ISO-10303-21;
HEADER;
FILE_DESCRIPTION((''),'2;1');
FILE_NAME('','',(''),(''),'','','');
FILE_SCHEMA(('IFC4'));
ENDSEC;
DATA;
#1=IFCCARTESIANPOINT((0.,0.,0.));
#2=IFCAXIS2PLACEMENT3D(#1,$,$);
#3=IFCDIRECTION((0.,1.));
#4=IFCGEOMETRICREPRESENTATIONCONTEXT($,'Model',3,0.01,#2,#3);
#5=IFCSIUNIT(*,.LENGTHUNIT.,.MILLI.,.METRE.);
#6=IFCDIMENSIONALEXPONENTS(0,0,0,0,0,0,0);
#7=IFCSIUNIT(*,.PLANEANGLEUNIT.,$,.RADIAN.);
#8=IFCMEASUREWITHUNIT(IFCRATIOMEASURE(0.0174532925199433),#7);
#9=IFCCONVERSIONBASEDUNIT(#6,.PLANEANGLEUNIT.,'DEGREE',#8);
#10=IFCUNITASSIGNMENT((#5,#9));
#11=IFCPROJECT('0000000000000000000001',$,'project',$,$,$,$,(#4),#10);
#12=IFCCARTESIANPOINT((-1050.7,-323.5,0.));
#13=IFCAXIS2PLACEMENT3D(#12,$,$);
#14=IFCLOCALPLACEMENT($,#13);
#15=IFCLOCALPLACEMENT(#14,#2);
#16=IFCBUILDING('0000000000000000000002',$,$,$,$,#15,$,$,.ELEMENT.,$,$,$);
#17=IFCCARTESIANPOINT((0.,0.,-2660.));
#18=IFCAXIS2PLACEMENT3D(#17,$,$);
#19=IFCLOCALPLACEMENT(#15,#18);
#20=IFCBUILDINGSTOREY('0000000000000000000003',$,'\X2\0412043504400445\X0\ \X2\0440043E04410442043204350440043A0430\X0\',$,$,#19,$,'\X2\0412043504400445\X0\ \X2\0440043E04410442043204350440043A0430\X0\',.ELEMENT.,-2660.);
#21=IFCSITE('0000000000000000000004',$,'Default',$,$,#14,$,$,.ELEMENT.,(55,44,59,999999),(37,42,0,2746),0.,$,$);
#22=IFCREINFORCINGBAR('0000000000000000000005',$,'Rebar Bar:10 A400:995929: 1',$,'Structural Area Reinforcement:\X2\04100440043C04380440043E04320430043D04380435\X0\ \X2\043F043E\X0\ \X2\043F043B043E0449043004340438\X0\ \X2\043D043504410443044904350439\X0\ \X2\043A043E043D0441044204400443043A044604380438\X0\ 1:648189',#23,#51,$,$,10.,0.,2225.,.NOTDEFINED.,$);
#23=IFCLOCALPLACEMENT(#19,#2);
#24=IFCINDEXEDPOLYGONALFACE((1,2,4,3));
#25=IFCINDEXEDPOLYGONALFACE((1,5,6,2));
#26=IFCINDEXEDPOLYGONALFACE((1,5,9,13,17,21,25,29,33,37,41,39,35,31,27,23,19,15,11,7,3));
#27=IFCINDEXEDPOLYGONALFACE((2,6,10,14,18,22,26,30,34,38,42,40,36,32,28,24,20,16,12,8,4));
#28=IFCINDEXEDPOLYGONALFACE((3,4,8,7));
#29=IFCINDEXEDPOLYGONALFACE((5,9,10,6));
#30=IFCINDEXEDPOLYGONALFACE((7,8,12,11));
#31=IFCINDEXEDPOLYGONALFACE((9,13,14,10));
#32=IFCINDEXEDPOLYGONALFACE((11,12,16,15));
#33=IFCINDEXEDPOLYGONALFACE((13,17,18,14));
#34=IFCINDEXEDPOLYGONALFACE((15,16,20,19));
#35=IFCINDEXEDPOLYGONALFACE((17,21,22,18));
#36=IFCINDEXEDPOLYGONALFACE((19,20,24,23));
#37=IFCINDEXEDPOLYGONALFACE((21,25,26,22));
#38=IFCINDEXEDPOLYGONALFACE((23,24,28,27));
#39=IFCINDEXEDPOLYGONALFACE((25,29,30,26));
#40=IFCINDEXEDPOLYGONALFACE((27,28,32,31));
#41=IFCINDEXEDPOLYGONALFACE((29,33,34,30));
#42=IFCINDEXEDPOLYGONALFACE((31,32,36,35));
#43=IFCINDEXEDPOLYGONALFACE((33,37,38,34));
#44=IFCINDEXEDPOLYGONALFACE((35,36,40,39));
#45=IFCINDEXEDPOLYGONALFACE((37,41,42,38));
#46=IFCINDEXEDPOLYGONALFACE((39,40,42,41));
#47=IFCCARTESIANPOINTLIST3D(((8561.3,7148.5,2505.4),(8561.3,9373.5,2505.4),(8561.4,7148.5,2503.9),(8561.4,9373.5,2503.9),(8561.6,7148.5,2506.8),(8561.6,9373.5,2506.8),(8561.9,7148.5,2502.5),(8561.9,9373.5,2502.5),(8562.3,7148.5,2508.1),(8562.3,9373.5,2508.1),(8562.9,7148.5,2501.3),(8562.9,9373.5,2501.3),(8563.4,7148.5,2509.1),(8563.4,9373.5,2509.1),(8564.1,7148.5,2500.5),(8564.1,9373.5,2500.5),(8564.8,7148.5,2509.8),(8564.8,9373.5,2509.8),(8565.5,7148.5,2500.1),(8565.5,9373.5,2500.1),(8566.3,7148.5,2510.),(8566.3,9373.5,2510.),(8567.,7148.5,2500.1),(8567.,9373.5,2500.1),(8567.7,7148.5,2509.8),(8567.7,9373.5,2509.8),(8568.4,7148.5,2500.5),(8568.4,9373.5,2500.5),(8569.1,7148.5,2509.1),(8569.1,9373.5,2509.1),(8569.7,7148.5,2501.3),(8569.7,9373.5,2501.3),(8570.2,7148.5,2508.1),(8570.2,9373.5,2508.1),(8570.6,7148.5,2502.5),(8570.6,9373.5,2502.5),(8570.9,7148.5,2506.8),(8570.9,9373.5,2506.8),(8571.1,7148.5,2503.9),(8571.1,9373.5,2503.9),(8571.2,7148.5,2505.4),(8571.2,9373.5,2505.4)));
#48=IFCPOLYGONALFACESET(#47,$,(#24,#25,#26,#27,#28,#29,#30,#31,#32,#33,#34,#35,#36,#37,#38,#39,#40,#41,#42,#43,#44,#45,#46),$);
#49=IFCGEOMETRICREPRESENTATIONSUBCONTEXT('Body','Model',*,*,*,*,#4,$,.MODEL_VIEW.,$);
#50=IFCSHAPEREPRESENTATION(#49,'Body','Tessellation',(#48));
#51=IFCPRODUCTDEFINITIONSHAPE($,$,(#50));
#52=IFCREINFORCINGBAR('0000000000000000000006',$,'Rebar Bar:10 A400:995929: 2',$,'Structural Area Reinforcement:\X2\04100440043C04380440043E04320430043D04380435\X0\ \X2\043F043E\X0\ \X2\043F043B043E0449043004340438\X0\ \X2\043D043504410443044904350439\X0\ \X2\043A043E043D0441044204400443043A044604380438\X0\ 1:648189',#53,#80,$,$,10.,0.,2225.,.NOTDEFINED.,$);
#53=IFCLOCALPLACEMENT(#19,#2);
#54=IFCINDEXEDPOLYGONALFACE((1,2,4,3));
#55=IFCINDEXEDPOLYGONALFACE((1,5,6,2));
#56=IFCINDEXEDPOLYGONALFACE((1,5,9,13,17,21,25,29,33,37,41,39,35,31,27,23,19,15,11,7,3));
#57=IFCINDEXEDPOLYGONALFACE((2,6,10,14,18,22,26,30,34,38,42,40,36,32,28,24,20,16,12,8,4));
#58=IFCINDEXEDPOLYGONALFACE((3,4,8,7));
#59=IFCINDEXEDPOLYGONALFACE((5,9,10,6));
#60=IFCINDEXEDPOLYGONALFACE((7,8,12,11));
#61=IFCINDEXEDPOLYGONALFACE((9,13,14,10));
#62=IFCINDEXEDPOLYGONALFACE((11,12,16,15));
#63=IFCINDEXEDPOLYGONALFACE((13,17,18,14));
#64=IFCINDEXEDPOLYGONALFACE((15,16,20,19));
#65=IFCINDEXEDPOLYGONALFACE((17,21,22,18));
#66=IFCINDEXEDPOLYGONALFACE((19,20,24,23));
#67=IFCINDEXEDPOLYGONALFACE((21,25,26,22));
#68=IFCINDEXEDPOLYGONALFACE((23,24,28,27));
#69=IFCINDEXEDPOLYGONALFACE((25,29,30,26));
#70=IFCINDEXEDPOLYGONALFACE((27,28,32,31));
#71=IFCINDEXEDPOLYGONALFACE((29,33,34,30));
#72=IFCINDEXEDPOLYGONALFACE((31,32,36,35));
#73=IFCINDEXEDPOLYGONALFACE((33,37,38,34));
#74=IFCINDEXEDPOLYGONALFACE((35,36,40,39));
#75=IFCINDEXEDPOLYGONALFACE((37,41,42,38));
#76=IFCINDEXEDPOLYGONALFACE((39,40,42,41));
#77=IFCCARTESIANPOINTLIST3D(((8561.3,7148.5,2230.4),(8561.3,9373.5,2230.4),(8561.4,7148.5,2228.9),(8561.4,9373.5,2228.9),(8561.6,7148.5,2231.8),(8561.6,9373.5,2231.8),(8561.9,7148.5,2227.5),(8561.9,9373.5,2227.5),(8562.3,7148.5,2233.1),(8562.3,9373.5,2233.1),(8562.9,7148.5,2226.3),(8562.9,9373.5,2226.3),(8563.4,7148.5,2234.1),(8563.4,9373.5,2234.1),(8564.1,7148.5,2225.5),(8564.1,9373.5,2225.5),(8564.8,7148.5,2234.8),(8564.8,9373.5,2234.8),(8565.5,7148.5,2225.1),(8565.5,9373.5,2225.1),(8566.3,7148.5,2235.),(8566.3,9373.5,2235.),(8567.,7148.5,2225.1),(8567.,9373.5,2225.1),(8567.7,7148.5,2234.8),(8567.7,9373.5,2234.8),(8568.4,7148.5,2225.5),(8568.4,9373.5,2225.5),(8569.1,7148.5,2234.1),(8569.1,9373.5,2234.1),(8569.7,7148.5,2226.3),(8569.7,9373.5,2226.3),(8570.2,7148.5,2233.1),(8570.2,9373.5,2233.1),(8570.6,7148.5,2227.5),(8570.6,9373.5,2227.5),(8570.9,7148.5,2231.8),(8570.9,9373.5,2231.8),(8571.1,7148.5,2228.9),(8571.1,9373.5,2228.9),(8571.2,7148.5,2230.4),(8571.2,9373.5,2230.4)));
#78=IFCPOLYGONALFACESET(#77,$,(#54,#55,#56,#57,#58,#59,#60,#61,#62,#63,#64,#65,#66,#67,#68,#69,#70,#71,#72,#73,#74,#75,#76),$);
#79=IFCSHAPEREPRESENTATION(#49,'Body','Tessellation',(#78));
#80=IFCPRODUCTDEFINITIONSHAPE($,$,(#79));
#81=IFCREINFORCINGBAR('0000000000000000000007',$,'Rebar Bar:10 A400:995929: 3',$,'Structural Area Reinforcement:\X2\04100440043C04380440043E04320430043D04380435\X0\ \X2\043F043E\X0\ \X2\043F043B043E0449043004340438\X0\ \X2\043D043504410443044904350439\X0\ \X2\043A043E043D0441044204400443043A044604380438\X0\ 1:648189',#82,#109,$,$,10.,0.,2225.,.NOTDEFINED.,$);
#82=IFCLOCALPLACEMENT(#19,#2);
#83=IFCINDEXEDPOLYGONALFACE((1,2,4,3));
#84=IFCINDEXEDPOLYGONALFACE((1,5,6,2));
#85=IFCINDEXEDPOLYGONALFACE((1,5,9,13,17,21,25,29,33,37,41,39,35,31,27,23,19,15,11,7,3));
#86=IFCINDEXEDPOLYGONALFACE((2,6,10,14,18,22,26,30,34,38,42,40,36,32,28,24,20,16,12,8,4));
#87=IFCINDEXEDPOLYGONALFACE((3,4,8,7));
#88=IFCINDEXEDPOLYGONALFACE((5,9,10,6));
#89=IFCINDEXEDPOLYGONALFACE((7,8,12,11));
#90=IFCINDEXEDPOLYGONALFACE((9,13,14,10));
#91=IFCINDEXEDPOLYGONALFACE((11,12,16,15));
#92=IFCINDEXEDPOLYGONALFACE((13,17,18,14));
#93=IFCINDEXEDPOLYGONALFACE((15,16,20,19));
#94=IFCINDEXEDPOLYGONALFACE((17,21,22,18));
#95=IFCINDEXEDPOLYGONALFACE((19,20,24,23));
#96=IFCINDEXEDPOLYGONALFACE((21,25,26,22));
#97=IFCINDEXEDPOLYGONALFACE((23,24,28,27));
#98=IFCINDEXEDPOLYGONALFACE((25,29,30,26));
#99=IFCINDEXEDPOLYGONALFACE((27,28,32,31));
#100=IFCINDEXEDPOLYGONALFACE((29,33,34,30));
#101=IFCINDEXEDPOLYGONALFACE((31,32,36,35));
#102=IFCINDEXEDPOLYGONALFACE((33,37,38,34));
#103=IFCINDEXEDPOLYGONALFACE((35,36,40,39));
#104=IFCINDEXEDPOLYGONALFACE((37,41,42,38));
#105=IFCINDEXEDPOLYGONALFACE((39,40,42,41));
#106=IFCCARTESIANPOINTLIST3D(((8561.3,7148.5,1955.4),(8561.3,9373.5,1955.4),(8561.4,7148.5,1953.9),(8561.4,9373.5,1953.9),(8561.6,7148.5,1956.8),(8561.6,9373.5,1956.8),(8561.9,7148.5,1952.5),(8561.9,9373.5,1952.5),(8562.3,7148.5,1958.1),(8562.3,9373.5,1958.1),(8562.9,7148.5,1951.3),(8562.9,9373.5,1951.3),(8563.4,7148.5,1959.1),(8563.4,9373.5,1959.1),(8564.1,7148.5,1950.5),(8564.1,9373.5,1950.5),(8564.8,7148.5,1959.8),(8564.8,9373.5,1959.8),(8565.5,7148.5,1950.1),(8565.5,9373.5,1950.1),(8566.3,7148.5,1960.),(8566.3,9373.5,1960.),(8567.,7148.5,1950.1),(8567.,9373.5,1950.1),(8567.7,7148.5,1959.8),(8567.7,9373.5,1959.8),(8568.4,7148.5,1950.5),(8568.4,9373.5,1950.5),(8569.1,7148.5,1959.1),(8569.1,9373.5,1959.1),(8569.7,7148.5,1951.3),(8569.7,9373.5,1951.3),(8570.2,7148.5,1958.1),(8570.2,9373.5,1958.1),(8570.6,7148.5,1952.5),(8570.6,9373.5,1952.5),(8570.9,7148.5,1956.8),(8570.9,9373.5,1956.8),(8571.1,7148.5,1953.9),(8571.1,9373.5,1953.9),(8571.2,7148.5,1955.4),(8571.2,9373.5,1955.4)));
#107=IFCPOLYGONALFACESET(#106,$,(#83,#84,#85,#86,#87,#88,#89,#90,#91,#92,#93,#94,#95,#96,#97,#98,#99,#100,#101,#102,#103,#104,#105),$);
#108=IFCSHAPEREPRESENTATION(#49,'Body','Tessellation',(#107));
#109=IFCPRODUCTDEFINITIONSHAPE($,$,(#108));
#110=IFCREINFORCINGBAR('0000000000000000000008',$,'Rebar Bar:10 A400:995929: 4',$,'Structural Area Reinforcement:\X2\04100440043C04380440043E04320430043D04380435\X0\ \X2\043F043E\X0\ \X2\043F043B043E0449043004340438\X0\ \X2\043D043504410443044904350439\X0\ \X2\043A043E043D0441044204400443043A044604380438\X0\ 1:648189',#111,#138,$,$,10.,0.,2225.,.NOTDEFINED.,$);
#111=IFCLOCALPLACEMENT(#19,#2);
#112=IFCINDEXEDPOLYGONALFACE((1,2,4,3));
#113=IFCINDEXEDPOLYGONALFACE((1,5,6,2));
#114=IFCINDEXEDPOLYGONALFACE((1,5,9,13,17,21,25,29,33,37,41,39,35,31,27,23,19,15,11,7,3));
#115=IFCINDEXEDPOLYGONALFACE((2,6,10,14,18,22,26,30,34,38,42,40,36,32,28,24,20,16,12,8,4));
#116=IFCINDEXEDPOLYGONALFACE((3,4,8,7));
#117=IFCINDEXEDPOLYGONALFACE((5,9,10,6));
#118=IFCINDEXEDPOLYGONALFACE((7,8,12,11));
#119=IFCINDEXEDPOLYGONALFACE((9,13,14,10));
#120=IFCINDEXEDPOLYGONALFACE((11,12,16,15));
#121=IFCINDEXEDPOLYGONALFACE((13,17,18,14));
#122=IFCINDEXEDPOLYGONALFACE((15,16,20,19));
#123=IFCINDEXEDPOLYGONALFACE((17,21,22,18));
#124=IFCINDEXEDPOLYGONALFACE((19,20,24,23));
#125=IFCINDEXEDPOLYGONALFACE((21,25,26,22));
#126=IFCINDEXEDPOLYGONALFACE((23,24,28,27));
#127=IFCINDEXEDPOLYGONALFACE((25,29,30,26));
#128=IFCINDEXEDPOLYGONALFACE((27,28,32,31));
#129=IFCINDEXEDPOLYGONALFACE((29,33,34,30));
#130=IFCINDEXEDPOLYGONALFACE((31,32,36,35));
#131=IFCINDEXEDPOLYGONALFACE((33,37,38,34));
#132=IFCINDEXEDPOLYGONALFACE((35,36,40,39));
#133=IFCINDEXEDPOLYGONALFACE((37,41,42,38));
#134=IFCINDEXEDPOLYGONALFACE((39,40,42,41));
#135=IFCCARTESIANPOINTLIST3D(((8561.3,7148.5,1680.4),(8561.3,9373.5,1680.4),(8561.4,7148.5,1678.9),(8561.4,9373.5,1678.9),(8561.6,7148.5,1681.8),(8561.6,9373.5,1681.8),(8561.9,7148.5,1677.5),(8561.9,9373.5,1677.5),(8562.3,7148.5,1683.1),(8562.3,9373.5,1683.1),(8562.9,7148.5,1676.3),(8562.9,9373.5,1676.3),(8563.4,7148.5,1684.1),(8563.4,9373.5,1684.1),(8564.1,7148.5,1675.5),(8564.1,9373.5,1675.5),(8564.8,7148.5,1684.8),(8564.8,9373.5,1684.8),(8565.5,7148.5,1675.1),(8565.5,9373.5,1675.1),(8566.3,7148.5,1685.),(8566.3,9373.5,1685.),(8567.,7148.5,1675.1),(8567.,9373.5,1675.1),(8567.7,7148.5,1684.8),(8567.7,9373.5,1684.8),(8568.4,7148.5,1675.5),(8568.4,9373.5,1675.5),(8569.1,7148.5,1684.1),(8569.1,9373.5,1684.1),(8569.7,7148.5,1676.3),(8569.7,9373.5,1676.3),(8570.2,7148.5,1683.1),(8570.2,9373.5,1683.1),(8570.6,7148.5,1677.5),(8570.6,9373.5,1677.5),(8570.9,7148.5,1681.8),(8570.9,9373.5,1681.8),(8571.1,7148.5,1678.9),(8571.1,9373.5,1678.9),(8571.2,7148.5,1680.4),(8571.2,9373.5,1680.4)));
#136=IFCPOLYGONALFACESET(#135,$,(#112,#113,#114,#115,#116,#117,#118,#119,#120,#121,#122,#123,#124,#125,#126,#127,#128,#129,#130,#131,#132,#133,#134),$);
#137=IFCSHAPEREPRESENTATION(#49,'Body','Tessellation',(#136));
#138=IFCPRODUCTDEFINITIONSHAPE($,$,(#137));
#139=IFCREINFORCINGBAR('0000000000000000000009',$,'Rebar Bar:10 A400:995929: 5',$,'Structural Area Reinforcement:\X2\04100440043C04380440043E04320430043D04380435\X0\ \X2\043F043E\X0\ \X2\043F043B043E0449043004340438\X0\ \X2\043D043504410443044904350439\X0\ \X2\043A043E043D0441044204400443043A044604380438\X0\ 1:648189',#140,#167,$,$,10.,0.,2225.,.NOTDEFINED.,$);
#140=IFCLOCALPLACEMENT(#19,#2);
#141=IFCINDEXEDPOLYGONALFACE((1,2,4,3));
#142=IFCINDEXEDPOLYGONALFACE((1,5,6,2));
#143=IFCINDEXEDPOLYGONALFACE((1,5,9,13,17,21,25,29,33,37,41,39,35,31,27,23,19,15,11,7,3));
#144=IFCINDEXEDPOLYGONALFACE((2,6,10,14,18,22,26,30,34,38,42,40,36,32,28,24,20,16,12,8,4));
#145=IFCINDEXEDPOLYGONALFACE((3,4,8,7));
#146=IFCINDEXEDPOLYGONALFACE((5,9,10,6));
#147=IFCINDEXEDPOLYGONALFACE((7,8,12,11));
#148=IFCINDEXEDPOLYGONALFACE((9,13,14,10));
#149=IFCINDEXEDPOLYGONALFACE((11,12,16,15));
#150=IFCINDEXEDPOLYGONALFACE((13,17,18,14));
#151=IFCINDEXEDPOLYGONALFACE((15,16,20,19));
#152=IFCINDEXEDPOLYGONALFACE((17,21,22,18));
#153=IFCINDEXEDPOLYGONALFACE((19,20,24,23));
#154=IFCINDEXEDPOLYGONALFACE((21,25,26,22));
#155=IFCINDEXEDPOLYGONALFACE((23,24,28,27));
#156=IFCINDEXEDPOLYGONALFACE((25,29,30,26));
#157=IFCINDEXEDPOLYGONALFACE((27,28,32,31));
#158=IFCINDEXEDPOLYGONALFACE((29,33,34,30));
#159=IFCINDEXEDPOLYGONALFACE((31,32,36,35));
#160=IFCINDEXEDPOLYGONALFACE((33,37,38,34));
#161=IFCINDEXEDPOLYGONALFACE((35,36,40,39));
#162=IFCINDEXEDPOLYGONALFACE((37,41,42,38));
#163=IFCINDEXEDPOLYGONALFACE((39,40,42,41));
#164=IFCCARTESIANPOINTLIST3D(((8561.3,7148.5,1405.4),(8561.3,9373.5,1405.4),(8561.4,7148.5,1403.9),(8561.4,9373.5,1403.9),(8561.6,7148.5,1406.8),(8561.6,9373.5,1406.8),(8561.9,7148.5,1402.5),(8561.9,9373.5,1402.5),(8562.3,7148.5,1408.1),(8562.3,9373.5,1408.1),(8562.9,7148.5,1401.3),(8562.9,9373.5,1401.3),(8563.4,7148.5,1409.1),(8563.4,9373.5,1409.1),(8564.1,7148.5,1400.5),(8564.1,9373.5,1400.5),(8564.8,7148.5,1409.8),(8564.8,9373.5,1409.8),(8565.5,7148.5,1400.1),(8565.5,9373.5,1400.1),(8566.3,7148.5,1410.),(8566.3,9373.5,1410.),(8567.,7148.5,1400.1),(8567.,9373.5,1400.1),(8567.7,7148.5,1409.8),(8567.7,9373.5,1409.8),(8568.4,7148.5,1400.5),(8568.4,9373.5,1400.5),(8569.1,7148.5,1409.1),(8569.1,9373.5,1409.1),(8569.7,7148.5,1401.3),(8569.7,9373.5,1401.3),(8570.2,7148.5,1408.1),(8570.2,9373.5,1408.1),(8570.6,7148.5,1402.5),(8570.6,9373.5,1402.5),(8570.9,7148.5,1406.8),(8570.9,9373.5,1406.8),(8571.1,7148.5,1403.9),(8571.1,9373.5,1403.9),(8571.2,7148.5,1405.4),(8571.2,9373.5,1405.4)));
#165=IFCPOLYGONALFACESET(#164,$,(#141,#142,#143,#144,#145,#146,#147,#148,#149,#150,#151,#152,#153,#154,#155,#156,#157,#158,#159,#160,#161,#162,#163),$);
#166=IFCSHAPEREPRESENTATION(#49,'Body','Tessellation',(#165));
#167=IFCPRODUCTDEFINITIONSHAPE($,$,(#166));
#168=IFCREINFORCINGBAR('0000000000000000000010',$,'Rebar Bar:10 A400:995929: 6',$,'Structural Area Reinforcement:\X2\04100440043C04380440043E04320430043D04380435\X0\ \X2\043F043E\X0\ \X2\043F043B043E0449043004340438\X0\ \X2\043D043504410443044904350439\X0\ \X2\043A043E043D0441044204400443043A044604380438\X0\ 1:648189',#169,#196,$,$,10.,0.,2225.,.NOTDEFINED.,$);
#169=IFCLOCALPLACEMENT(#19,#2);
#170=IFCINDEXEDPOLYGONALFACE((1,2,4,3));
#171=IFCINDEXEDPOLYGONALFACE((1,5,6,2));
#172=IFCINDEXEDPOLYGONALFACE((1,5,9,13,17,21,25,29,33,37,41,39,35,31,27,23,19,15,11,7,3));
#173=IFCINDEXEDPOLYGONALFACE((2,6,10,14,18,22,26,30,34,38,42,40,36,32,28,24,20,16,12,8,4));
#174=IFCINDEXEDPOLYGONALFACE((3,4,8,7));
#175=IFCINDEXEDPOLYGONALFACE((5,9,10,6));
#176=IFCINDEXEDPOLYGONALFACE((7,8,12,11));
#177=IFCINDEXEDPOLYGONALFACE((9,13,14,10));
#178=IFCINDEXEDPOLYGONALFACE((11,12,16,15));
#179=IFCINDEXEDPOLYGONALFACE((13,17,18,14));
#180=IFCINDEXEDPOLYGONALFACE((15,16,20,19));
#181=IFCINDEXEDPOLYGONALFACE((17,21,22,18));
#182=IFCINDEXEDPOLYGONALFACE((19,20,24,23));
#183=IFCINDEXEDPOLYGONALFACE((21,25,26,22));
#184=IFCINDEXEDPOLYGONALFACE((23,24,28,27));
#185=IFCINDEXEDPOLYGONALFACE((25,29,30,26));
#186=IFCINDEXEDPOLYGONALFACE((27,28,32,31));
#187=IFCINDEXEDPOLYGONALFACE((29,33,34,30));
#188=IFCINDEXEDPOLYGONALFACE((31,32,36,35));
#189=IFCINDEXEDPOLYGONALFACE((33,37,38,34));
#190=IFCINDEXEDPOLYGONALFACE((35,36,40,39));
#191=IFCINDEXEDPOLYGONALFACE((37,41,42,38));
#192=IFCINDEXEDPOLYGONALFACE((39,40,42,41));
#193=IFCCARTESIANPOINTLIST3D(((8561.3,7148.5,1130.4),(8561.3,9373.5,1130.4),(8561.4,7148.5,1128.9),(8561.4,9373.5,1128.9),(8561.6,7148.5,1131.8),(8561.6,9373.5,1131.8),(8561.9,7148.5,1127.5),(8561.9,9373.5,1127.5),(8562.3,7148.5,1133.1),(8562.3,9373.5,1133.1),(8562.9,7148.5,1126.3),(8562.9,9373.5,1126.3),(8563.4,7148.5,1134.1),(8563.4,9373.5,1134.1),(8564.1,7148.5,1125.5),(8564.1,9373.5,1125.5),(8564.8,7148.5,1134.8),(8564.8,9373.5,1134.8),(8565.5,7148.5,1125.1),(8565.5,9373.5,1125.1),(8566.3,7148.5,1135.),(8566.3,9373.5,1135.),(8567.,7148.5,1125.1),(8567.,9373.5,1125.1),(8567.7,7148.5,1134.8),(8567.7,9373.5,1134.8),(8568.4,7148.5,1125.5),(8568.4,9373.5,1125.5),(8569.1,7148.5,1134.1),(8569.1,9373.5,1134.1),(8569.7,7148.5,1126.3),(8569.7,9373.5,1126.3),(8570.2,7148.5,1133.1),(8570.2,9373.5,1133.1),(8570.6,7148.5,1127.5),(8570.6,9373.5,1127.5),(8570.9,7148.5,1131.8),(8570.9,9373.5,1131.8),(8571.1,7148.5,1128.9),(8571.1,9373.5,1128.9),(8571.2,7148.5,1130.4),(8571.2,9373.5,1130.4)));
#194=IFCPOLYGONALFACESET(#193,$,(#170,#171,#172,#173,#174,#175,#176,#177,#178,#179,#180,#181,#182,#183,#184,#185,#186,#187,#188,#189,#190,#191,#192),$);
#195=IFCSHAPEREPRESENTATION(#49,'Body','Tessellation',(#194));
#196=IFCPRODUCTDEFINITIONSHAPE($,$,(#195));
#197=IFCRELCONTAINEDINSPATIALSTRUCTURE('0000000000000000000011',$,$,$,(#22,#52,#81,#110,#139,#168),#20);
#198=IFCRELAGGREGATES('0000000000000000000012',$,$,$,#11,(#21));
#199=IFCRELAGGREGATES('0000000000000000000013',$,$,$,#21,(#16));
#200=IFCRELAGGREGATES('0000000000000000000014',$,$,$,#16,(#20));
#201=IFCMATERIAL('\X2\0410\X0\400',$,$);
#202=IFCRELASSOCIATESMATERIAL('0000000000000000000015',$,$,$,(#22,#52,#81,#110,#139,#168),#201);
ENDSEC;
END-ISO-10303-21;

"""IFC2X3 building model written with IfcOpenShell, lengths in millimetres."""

from ifc_helpers import new_model, entity, si_unit, converted_unit, direction, frame, origin, place, context, subcontext, project, spatial, material, element, save


model = new_model("IFC2X3")

# Units and contexts
model_context = context("Model", 3, precision=0.01, world=origin(), true_north=direction((0.0, 1.0)))
body_context = subcontext(model_context, "Body", "Model", "MODEL_VIEW")
ifc_project = project(units=[si_unit("LENGTHUNIT", "METRE", prefix="MILLI"), converted_unit("PLANEANGLEUNIT", "DEGREE", entity("IfcRatioMeasure", 0.0174532925199433), si_unit("PLANEANGLEUNIT", "RADIAN"), dimensions=[0, 0, 0, 0, 0, 0, 0])], contexts=[model_context])

# Site, building, storey
site_placement = place(None, frame((-1050.7, -323.5, 0.0)))
site = spatial("IfcSite", under=ifc_project, at=site_placement, Name="Default", CompositionType="ELEMENT", RefLatitude=(55, 44, 59, 999999), RefLongitude=(37, 42, 0, 2746), RefElevation=0.0)
building_placement = place(site_placement, origin())
building = spatial("IfcBuilding", under=site, at=building_placement, CompositionType="ELEMENT")
storey_placement = place(building_placement, frame((0.0, 0.0, -2660.0)))
storey = spatial("IfcBuildingStorey", under=building, at=storey_placement, Name="Верх ростверка", LongName="Верх ростверка", CompositionType="ELEMENT", Elevation=-2660.0)

# Reinforcing bars
ifc_material = material(Name="А400")
reinforcing_bar_1_placement = place(storey_placement, origin())
element("IfcReinforcingBar", 1, at=reinforcing_bar_1_placement, inside=storey, material=ifc_material, Name="Rebar Bar:10 A400:995929: 1", ObjectType="Structural Area Reinforcement:Армирование по площади несущей конструкции 1:648189", BarLength=2225.0, BarRole="NOTDEFINED", CrossSectionArea=0.0, NominalDiameter=10.0, context=body_context, shape_type="AdvancedSweptSolid", body=[
    entity("IfcSweptDiskSolid", entity("IfcCompositeCurve", [entity("IfcCompositeCurveSegment", "CONTINUOUS", True, entity("IfcPolyline", [entity("IfcCartesianPoint", [8566.3, 7148.5, 2505.0]), entity("IfcCartesianPoint", [8566.3, 9373.5, 2505.0])]))], False), 5.0, None, 0.0, 1.0),
])
reinforcing_bar_2_placement = place(storey_placement, origin())
element("IfcReinforcingBar", 2, at=reinforcing_bar_2_placement, inside=storey, material=ifc_material, Name="Rebar Bar:10 A400:995929: 2", ObjectType="Structural Area Reinforcement:Армирование по площади несущей конструкции 1:648189", BarLength=2225.0, BarRole="NOTDEFINED", CrossSectionArea=0.0, NominalDiameter=10.0, context=body_context, shape_type="AdvancedSweptSolid", body=[
    entity("IfcSweptDiskSolid", entity("IfcCompositeCurve", [entity("IfcCompositeCurveSegment", "CONTINUOUS", True, entity("IfcPolyline", [entity("IfcCartesianPoint", [8566.3, 7148.5, 2230.0]), entity("IfcCartesianPoint", [8566.3, 9373.5, 2230.0])]))], False), 5.0, None, 0.0, 1.0),
])
reinforcing_bar_3_placement = place(storey_placement, origin())
element("IfcReinforcingBar", 3, at=reinforcing_bar_3_placement, inside=storey, material=ifc_material, Name="Rebar Bar:10 A400:995929: 3", ObjectType="Structural Area Reinforcement:Армирование по площади несущей конструкции 1:648189", BarLength=2225.0, BarRole="NOTDEFINED", CrossSectionArea=0.0, NominalDiameter=10.0, context=body_context, shape_type="AdvancedSweptSolid", body=[
    entity("IfcSweptDiskSolid", entity("IfcCompositeCurve", [entity("IfcCompositeCurveSegment", "CONTINUOUS", True, entity("IfcPolyline", [entity("IfcCartesianPoint", [8566.3, 7148.5, 1955.0]), entity("IfcCartesianPoint", [8566.3, 9373.5, 1955.0])]))], False), 5.0, None, 0.0, 1.0),
])
reinforcing_bar_4_placement = place(storey_placement, origin())
element("IfcReinforcingBar", 4, at=reinforcing_bar_4_placement, inside=storey, material=ifc_material, Name="Rebar Bar:10 A400:995929: 4", ObjectType="Structural Area Reinforcement:Армирование по площади несущей конструкции 1:648189", BarLength=2225.0, BarRole="NOTDEFINED", CrossSectionArea=0.0, NominalDiameter=10.0, context=body_context, shape_type="AdvancedSweptSolid", body=[
    entity("IfcSweptDiskSolid", entity("IfcCompositeCurve", [entity("IfcCompositeCurveSegment", "CONTINUOUS", True, entity("IfcPolyline", [entity("IfcCartesianPoint", [8566.3, 7148.5, 1680.0]), entity("IfcCartesianPoint", [8566.3, 9373.5, 1680.0])]))], False), 5.0, None, 0.0, 1.0),
])
reinforcing_bar_5_placement = place(storey_placement, origin())
element("IfcReinforcingBar", 5, at=reinforcing_bar_5_placement, inside=storey, material=ifc_material, Name="Rebar Bar:10 A400:995929: 5", ObjectType="Structural Area Reinforcement:Армирование по площади несущей конструкции 1:648189", BarLength=2225.0, BarRole="NOTDEFINED", CrossSectionArea=0.0, NominalDiameter=10.0, context=body_context, shape_type="AdvancedSweptSolid", body=[
    entity("IfcSweptDiskSolid", entity("IfcCompositeCurve", [entity("IfcCompositeCurveSegment", "CONTINUOUS", True, entity("IfcPolyline", [entity("IfcCartesianPoint", [8566.3, 7148.5, 1405.0]), entity("IfcCartesianPoint", [8566.3, 9373.5, 1405.0])]))], False), 5.0, None, 0.0, 1.0),
])
reinforcing_bar_6_placement = place(storey_placement, origin())
element("IfcReinforcingBar", 6, at=reinforcing_bar_6_placement, inside=storey, material=ifc_material, Name="Rebar Bar:10 A400:995929: 6", ObjectType="Structural Area Reinforcement:Армирование по площади несущей конструкции 1:648189", BarLength=2225.0, BarRole="NOTDEFINED", CrossSectionArea=0.0, NominalDiameter=10.0, context=body_context, shape_type="AdvancedSweptSolid", body=[
    entity("IfcSweptDiskSolid", entity("IfcCompositeCurve", [entity("IfcCompositeCurveSegment", "CONTINUOUS", True, entity("IfcPolyline", [entity("IfcCartesianPoint", [8566.3, 7148.5, 1130.0]), entity("IfcCartesianPoint", [8566.3, 9373.5, 1130.0])]))], False), 5.0, None, 0.0, 1.0),
])

save(model, "model.ifc")
